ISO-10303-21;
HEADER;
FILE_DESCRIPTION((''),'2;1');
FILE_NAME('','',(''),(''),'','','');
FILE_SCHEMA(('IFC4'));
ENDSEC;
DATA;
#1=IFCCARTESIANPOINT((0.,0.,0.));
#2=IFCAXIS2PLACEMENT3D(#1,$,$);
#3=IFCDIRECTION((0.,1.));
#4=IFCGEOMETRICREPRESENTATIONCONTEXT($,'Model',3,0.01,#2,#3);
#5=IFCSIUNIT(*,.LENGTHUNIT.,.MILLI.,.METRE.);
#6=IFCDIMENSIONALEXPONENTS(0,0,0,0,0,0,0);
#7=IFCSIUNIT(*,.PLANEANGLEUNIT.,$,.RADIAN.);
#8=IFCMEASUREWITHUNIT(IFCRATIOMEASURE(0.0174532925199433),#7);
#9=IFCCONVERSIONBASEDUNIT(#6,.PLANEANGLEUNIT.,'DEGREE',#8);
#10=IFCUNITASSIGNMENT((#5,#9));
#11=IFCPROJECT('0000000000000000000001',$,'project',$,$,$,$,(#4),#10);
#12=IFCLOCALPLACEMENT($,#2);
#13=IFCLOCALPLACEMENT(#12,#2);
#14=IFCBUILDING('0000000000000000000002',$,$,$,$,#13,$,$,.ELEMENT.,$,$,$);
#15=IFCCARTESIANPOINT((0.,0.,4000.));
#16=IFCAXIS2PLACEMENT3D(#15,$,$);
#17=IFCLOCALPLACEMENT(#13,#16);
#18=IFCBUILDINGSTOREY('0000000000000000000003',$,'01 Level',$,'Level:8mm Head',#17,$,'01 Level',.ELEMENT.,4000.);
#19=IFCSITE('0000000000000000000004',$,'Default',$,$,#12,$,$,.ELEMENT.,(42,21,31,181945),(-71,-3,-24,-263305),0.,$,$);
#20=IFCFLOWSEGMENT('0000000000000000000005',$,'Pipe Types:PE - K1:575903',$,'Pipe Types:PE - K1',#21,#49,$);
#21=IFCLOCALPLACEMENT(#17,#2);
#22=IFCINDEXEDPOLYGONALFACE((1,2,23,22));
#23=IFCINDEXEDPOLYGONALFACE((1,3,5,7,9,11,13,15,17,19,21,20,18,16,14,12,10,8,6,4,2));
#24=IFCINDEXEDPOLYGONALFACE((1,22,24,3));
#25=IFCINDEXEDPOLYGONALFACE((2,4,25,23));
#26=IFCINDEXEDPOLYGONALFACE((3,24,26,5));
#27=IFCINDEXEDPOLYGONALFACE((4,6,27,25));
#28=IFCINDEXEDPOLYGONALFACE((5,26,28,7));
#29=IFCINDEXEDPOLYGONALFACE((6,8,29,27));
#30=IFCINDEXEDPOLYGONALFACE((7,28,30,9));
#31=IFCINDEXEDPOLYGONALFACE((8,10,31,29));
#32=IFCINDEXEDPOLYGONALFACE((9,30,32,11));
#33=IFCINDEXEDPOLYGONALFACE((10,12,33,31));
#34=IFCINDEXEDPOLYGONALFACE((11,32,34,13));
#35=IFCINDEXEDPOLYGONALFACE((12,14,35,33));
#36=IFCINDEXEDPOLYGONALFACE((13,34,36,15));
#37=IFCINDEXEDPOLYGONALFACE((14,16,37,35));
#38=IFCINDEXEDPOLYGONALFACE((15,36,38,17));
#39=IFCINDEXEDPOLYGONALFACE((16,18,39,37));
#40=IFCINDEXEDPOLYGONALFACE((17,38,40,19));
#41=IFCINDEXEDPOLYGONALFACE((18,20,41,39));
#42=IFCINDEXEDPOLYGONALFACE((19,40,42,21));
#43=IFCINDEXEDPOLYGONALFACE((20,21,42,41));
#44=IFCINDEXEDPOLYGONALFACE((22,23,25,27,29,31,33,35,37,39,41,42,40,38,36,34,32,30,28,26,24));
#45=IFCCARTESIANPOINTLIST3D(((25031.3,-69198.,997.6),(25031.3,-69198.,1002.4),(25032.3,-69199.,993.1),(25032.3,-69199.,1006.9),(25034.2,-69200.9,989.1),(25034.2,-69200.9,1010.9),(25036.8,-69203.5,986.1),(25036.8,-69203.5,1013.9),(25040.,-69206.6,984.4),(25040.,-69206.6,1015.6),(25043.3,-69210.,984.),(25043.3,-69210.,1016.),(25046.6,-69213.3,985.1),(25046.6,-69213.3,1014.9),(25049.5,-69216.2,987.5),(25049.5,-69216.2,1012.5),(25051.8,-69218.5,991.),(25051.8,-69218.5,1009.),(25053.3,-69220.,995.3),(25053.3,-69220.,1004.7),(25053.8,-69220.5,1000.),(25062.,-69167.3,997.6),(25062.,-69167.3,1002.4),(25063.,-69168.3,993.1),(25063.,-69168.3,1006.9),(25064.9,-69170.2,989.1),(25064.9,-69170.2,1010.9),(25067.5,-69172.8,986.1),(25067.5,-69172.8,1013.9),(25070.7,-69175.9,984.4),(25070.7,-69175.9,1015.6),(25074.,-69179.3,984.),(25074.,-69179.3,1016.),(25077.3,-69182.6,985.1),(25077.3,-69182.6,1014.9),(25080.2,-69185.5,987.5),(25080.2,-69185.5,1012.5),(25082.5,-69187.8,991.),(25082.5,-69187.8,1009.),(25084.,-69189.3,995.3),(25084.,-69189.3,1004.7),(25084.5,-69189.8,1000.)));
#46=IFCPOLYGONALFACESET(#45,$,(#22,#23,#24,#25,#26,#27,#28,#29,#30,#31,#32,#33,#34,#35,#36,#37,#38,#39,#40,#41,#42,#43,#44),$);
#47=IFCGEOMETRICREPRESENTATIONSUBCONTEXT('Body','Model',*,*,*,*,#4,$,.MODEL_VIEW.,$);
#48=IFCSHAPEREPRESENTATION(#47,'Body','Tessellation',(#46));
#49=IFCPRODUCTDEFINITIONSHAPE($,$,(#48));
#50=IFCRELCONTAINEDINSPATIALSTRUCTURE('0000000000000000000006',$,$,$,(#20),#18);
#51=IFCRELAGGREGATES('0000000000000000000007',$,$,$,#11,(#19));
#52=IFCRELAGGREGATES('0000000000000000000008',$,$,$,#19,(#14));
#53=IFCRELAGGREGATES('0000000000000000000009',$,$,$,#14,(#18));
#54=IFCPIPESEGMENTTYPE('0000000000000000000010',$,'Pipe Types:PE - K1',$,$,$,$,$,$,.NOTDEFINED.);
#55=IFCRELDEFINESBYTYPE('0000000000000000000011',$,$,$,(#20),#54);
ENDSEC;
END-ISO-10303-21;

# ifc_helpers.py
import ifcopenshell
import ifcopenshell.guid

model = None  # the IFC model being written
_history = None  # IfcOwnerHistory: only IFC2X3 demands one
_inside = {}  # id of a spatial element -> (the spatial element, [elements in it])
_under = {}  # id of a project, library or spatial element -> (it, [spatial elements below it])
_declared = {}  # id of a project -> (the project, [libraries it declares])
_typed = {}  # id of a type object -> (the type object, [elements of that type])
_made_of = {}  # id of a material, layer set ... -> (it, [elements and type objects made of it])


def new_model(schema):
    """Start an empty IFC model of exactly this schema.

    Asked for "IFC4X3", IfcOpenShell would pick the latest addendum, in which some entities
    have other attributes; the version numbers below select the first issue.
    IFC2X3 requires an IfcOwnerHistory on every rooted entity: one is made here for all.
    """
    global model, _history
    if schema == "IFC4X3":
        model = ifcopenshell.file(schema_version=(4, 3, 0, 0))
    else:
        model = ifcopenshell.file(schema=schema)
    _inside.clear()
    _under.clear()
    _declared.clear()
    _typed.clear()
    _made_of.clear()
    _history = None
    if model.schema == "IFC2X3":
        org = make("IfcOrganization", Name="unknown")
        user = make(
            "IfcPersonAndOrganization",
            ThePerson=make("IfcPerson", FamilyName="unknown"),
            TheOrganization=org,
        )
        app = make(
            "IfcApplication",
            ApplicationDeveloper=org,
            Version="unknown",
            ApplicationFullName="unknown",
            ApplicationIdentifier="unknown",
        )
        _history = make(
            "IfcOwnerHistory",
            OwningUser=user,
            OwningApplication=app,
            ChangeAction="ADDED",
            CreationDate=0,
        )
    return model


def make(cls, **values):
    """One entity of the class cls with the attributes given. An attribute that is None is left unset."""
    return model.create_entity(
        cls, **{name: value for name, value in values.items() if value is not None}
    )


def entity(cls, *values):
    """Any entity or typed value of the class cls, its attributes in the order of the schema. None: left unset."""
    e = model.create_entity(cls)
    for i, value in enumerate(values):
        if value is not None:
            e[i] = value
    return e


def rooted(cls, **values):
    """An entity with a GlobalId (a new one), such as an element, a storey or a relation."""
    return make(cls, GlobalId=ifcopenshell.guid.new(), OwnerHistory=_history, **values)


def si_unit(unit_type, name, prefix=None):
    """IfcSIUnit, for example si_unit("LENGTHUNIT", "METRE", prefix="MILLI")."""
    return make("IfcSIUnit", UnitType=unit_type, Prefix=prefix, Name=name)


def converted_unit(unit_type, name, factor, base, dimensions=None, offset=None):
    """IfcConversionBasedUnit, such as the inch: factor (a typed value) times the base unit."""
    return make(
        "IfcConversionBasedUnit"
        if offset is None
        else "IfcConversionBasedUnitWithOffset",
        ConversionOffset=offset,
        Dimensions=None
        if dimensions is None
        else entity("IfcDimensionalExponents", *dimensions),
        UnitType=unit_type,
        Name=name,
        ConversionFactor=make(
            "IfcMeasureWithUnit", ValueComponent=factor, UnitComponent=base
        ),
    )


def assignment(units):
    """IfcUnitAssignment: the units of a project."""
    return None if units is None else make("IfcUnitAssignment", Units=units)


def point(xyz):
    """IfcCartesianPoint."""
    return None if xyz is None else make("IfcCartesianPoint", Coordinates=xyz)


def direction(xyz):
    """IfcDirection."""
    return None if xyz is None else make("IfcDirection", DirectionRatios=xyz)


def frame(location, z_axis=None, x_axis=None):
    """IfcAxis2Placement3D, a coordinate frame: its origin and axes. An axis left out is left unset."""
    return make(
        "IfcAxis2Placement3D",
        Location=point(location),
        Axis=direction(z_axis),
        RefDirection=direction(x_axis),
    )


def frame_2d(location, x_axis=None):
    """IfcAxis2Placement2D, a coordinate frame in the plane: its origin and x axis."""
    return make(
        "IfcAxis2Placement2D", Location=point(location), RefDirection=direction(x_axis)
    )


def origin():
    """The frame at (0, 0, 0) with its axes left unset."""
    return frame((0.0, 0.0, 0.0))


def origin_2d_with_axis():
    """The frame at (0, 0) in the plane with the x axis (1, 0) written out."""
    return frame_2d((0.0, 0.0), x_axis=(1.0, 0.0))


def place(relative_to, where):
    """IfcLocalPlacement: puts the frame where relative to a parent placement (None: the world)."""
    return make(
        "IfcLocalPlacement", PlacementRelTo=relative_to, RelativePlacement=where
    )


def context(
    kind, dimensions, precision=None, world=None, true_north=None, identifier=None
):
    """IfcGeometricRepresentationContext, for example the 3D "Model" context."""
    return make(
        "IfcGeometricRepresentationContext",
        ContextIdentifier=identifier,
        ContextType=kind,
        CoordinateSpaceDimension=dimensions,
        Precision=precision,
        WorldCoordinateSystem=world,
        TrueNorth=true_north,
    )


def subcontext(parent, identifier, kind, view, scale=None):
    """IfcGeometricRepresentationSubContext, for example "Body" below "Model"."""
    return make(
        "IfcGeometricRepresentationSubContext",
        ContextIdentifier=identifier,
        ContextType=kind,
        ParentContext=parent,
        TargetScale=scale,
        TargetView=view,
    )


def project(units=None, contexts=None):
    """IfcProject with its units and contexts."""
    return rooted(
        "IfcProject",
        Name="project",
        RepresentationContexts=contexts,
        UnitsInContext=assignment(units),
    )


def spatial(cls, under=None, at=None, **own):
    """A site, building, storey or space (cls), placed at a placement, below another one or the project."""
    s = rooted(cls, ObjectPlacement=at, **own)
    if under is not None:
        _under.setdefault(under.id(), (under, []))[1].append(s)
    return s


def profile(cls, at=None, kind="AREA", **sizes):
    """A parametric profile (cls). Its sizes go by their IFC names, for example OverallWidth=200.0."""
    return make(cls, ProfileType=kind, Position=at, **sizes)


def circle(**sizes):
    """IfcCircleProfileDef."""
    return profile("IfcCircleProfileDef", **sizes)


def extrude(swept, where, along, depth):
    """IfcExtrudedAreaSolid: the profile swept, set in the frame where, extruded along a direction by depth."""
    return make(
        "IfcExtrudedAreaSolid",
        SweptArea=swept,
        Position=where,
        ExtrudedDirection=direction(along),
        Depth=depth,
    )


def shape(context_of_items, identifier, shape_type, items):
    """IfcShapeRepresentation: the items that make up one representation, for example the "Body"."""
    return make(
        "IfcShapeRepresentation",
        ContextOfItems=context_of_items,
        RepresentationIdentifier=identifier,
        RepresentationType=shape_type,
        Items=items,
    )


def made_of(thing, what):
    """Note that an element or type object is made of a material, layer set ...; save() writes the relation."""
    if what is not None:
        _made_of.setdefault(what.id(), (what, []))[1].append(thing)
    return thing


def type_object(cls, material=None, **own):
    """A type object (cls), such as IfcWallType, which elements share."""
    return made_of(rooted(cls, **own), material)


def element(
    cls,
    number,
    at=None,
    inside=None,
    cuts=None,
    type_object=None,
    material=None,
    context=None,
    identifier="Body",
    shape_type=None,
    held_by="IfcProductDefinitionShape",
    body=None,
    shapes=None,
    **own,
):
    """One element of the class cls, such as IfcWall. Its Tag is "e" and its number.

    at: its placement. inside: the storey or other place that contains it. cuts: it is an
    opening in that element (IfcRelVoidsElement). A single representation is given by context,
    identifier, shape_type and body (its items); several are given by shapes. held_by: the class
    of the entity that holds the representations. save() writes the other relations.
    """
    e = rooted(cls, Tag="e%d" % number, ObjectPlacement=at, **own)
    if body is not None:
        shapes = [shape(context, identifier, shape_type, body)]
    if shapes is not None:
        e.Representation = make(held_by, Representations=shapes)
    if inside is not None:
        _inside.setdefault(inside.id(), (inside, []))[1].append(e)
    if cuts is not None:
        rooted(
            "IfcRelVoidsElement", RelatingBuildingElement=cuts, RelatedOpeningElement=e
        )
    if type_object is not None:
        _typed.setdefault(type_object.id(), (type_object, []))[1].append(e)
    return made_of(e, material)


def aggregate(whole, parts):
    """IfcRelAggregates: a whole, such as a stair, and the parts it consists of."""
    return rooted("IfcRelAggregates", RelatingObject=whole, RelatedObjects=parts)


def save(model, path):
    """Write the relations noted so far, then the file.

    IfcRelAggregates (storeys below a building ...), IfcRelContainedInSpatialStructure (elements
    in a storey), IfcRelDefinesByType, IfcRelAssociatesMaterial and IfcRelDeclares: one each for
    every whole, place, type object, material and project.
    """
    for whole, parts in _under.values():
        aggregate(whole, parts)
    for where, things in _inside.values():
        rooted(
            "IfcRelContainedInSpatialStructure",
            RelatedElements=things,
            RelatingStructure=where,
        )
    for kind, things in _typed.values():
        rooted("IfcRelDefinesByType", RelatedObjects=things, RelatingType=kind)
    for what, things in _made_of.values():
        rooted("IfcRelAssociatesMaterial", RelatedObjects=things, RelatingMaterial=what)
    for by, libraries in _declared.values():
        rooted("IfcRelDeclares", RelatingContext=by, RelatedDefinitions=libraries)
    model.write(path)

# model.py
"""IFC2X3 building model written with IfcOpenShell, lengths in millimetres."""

from ifc_helpers import new_model, entity, si_unit, converted_unit, direction, frame, origin, origin_2d_with_axis, place, context, subcontext, project, spatial, circle, extrude, type_object, element, save


model = new_model("IFC2X3")

# Units and contexts
model_context = context("Model", 3, precision=0.01, world=origin(), true_north=direction((0.0, 1.0)))
body_context = subcontext(model_context, "Body", "Model", "MODEL_VIEW")
ifc_project = project(units=[si_unit("LENGTHUNIT", "METRE", prefix="MILLI"), converted_unit("PLANEANGLEUNIT", "DEGREE", entity("IfcRatioMeasure", 0.0174532925199433), si_unit("PLANEANGLEUNIT", "RADIAN"), dimensions=[0, 0, 0, 0, 0, 0, 0])], contexts=[model_context])

# Site, building, storey
site_placement = place(None, origin())
site = spatial("IfcSite", under=ifc_project, at=site_placement, Name="Default", CompositionType="ELEMENT", RefLatitude=(42, 21, 31, 181945), RefLongitude=(-71, -3, -24, -263305), RefElevation=0.0)
building_placement = place(site_placement, origin())
building = spatial("IfcBuilding", under=site, at=building_placement, CompositionType="ELEMENT")
storey_placement = place(building_placement, frame((0.0, 0.0, 4000.0)))
storey = spatial("IfcBuildingStorey", under=building, at=storey_placement, Name="01 Level", ObjectType="Level:8mm Head", LongName="01 Level", CompositionType="ELEMENT", Elevation=4000.0)

# Flow segment
pipe_segment_type = type_object("IfcPipeSegmentType", Name="Pipe Types:PE - K1", PredefinedType="NOTDEFINED")
flow_segment_1_placement = place(storey_placement, frame((25029.6, -69222.1, 982.4)))
element("IfcFlowSegment", 1, at=flow_segment_1_placement, inside=storey, type_object=pipe_segment_type, Name="Pipe Types:PE - K1:575903", ObjectType="Pipe Types:PE - K1", context=body_context, shape_type="SweptSolid", body=[
    extrude(circle(Radius=16.0, at=origin_2d_with_axis()), frame((12.9, 12.9, 17.6), z_axis=(0.707107, 0.707107, 0.0), x_axis=(0.707107, -0.707107, 0.0)), (0.0, 0.0, 1.0), 43.4),
])

save(model, "model.ifc")
